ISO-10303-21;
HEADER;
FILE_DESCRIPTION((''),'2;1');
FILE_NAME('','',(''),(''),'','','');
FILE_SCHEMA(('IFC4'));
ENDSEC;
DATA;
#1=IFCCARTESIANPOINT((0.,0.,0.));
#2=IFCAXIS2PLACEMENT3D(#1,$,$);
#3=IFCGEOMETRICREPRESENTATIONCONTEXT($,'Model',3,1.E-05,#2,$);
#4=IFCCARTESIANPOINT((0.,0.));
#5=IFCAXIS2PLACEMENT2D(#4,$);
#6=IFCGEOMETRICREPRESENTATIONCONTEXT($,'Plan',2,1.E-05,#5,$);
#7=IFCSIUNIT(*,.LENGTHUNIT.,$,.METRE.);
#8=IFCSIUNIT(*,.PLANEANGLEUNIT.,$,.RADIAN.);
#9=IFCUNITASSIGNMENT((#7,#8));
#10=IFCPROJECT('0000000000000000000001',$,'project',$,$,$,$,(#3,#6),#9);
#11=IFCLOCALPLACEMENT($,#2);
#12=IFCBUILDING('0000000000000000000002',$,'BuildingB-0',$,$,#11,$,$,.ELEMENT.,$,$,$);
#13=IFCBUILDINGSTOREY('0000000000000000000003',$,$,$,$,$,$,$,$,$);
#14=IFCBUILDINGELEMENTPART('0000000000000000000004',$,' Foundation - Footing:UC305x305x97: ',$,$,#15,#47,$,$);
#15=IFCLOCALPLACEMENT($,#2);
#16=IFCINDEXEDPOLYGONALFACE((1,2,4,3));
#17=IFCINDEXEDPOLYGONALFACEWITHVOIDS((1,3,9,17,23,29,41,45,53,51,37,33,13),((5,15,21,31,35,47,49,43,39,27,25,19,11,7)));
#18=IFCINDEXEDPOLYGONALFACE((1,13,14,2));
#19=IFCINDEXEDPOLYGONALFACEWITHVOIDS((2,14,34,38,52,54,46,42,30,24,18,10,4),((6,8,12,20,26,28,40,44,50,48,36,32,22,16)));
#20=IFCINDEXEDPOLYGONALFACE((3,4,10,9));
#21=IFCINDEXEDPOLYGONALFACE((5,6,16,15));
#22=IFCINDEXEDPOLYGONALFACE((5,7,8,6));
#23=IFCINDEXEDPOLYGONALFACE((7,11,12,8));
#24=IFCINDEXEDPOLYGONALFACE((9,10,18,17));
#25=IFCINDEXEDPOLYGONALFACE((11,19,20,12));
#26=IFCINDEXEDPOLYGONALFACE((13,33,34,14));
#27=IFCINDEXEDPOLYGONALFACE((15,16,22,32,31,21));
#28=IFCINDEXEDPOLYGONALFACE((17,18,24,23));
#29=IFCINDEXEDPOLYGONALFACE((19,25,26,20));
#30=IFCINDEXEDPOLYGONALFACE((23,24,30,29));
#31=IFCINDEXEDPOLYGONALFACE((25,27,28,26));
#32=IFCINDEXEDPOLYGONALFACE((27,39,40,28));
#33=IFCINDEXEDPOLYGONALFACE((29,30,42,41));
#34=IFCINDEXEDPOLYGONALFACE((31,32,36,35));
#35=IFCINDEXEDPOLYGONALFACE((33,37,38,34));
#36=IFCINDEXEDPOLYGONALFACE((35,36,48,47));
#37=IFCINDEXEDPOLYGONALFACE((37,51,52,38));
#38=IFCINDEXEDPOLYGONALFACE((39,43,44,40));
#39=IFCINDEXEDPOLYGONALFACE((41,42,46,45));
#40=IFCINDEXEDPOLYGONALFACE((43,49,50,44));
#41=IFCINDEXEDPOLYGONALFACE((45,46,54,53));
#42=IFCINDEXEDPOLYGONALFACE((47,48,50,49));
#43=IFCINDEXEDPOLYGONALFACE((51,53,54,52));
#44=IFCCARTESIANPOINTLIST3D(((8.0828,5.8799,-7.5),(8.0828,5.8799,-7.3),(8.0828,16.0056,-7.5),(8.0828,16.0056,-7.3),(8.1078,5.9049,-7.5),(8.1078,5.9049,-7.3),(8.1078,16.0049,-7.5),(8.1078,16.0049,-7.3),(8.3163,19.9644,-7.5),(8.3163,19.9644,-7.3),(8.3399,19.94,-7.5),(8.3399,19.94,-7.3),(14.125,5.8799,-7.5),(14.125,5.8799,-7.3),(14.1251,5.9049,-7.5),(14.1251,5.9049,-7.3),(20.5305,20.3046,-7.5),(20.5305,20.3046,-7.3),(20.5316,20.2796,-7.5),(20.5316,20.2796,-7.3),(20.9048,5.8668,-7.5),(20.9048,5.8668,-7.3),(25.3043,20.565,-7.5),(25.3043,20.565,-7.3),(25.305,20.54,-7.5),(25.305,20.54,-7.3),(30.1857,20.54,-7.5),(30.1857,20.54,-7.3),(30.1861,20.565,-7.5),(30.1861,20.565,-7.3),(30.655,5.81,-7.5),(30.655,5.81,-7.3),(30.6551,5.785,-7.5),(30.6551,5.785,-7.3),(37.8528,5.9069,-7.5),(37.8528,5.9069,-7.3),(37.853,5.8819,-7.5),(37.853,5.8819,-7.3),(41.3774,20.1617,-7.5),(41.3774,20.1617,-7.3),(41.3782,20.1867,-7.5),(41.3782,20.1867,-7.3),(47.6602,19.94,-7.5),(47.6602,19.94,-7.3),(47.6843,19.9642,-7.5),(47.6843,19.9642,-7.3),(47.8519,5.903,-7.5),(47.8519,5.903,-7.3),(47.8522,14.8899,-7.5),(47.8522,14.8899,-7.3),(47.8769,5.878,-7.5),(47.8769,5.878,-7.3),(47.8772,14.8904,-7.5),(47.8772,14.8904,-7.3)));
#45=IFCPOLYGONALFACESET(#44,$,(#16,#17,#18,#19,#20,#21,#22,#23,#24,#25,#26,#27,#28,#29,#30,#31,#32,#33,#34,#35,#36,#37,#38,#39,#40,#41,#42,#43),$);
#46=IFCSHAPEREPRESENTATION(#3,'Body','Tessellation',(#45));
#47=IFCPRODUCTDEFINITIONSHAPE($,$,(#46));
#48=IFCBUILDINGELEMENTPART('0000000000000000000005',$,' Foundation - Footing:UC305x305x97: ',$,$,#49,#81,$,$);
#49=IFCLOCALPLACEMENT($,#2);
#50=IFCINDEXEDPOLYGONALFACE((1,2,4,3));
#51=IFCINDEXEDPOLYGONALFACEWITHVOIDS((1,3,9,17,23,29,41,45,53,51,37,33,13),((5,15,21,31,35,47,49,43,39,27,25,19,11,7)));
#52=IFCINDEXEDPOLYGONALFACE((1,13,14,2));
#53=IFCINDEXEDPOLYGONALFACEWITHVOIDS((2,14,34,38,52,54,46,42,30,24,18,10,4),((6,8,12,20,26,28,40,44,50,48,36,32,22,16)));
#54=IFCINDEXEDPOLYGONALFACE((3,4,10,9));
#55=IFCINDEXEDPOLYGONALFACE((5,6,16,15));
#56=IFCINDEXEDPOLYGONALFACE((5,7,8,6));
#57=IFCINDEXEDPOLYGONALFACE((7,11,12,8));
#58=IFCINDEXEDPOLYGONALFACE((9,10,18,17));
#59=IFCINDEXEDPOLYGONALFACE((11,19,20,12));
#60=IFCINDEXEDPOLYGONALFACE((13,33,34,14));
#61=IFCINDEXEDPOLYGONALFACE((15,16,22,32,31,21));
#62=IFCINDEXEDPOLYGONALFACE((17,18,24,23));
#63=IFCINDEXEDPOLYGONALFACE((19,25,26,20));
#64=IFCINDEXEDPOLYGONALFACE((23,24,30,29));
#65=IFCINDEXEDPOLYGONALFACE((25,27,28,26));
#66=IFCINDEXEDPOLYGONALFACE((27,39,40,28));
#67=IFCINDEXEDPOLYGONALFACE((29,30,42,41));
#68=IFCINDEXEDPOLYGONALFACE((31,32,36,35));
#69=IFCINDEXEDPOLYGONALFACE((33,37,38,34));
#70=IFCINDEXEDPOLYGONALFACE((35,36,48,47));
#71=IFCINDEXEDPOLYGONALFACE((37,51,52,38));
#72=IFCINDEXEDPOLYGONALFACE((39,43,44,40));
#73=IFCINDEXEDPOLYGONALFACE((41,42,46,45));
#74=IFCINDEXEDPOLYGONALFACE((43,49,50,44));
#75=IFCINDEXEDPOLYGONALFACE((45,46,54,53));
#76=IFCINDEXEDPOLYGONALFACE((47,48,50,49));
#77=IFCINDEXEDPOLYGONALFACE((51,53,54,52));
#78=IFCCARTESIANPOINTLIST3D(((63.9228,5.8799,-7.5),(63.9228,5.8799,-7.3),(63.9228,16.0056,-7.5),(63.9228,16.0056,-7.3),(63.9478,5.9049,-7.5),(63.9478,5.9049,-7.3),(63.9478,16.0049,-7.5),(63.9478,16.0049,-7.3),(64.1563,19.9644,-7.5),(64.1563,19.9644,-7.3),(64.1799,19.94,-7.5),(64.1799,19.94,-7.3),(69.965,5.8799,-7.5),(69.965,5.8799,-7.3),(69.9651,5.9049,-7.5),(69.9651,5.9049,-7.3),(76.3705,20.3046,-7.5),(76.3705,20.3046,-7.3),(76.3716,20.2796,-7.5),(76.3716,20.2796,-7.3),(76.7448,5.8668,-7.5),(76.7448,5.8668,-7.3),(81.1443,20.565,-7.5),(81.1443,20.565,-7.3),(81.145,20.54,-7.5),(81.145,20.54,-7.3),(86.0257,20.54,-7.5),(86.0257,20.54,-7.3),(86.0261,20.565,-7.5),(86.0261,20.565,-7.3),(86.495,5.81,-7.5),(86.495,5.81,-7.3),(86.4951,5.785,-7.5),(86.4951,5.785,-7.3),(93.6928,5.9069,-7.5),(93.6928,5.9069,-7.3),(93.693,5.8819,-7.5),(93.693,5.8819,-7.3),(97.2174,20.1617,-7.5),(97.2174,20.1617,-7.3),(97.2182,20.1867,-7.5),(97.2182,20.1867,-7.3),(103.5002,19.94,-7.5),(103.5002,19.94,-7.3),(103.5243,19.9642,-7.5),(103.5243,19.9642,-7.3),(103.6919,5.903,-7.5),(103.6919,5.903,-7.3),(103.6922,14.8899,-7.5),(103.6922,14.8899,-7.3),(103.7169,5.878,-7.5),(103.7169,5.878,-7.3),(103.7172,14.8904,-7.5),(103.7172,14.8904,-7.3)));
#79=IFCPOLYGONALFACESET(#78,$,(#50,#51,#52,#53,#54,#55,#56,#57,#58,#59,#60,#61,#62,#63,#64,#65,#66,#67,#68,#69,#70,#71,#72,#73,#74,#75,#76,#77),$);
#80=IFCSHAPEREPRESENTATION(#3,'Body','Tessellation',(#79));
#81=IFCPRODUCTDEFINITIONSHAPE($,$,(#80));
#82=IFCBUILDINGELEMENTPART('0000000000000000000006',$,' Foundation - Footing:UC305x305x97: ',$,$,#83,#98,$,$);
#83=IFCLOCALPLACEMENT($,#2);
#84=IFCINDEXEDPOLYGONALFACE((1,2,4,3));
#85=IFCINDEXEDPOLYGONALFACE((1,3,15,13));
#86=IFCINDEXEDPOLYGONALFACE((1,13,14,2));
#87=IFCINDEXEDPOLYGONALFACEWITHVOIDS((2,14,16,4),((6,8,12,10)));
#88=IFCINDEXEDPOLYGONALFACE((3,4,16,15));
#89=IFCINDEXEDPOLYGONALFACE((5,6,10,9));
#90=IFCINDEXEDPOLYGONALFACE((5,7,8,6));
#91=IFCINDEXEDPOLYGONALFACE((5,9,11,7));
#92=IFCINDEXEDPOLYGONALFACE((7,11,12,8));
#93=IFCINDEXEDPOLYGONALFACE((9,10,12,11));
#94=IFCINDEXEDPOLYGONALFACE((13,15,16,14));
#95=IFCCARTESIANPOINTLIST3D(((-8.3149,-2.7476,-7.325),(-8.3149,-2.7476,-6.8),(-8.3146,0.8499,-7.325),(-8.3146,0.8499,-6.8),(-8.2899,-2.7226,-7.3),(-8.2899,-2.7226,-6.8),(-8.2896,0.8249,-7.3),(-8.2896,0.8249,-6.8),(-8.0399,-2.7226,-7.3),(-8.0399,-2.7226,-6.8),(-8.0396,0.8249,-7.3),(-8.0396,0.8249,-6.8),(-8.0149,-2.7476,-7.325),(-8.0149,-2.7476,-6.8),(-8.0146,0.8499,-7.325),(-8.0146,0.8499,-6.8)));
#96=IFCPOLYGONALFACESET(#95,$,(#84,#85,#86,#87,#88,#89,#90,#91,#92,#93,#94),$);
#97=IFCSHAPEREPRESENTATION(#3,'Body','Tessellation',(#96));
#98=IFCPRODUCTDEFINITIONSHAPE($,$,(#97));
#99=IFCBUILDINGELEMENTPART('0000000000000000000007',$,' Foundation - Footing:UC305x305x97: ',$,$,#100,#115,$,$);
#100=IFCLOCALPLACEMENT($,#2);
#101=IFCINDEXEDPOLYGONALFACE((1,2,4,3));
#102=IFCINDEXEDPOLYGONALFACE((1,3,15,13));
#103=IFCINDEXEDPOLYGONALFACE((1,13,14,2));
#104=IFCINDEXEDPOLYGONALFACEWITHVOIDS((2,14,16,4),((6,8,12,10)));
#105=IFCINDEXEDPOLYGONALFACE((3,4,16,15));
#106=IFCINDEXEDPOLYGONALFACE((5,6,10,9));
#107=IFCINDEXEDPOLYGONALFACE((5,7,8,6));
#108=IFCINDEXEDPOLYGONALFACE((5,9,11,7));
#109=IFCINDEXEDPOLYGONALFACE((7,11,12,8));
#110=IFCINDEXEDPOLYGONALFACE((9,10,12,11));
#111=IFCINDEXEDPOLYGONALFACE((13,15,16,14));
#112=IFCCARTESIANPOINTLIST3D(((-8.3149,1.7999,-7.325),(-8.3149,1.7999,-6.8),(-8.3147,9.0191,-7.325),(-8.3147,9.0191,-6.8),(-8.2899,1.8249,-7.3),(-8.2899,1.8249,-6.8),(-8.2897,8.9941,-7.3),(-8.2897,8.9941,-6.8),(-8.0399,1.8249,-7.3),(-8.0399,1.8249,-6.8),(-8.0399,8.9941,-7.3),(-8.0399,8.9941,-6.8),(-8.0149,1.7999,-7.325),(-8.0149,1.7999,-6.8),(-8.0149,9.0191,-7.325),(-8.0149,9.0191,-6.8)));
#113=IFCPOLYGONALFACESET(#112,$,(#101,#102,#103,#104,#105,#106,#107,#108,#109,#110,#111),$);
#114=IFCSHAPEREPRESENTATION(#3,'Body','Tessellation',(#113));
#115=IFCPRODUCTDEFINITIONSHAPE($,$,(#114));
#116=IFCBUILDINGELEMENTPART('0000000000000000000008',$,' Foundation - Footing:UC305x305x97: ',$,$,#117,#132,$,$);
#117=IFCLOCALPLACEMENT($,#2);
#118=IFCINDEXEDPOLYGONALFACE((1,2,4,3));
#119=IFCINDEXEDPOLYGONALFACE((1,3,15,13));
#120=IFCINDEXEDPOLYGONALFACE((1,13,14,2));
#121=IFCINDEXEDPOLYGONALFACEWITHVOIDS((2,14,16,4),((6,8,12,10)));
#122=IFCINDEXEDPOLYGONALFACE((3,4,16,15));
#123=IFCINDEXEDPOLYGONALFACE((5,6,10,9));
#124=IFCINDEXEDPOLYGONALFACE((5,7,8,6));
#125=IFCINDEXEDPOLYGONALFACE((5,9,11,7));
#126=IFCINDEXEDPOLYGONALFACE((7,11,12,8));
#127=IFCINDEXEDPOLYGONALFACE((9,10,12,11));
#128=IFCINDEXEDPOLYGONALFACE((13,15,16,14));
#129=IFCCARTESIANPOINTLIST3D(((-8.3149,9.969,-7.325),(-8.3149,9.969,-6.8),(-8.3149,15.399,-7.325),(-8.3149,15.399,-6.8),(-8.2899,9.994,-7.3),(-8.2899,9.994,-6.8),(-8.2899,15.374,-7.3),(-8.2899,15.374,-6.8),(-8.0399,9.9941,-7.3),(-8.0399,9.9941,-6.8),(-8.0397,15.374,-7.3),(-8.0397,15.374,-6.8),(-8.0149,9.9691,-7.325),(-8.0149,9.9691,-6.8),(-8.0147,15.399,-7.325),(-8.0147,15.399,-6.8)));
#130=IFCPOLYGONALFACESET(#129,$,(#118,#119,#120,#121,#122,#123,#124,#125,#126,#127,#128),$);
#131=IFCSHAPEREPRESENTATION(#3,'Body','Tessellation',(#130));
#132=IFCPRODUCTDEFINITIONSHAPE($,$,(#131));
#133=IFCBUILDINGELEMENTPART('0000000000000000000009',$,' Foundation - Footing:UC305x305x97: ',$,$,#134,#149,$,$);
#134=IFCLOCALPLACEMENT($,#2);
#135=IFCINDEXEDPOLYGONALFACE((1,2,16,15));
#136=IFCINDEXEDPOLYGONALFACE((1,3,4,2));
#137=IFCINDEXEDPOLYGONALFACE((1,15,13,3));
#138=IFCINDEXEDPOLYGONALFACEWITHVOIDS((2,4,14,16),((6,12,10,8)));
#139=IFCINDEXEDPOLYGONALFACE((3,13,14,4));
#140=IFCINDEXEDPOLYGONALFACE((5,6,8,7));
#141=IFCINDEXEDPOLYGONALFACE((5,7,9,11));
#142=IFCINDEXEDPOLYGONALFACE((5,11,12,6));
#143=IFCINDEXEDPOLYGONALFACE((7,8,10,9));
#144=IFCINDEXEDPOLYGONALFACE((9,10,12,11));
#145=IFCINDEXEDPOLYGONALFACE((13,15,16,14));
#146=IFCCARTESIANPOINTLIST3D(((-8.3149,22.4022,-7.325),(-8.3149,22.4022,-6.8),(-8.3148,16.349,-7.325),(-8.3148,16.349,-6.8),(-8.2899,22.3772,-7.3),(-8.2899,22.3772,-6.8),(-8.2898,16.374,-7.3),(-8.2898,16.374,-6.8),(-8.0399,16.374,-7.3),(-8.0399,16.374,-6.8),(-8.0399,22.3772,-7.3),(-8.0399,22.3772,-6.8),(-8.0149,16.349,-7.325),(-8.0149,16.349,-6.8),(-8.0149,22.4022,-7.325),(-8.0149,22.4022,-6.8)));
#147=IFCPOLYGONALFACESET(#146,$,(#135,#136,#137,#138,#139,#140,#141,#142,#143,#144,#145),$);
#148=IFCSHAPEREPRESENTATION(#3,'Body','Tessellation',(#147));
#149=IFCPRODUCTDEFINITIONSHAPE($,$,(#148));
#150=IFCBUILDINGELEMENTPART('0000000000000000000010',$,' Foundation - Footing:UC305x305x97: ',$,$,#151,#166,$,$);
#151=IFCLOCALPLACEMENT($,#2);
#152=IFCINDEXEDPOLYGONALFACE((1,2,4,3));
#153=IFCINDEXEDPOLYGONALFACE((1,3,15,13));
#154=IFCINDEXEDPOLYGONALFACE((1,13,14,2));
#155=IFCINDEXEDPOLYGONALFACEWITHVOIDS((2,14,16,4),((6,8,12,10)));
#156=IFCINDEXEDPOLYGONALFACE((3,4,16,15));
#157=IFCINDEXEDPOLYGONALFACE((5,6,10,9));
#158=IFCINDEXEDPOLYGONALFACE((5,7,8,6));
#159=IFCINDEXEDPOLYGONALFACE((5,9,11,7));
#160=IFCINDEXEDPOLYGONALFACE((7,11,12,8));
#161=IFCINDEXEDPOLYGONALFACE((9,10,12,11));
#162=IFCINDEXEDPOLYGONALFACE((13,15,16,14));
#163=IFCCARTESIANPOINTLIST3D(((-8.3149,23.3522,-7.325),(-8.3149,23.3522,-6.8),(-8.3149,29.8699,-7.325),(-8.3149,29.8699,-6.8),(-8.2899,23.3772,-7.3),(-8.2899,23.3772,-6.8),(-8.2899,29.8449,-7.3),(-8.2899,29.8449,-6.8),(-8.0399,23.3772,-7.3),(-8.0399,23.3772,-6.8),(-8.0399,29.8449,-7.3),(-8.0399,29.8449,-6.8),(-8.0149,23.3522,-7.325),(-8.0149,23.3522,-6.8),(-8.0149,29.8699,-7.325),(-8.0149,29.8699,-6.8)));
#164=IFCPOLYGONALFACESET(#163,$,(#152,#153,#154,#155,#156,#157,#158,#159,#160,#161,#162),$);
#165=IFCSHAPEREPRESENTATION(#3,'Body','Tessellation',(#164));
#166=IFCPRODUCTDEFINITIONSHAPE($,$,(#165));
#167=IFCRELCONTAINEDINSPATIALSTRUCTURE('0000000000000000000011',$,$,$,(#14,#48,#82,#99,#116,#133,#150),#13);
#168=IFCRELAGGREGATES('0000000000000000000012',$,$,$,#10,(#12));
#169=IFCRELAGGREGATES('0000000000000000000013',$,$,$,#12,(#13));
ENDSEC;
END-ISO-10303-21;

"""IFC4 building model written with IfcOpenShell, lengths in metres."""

from ifc_helpers import new_model, si_unit, origin, origin_2d, place, context, project, spatial, polyline, outline, extrude, element, save


model = new_model("IFC4")

# Units and contexts
model_context = context("Model", 3, precision=1e-05, world=origin())
plan_context = context("Plan", 2, precision=1e-05, world=origin_2d())
ifc_project = project(units=[si_unit("LENGTHUNIT", "METRE"), si_unit("PLANEANGLEUNIT", "RADIAN")], contexts=[model_context, plan_context])

# Building, storey
building_placement = place(None, origin())
building = spatial("IfcBuilding", under=ifc_project, at=building_placement, Name="BuildingB-0", CompositionType="ELEMENT")
storey = spatial("IfcBuildingStorey", under=building)

# Building element parts, openings
building_element_part_1 = element("IfcBuildingElementPart", 1, inside=storey, Name=" Foundation - Footing:UC305x305x97: ", context=model_context, shape_type="SweptSolid", body=[
    extrude(outline(polyline([(8.3163, 19.9644, -7.5), (20.5305, 20.3046, -7.5), (25.3043, 20.565, -7.5), (30.1861, 20.565, -7.5), (41.3782, 20.1867, -7.5), (47.6843, 19.9642, -7.5), (47.8772, 14.8904, -7.5), (47.8769, 5.878, -7.5), (37.853, 5.8819, -7.5), (30.6551, 5.785, -7.5), (20.9046, 5.8418, -7.5), (14.125, 5.8799, -7.5), (8.0828, 5.8799, -7.5), (8.0828, 16.0056, -7.5), (8.3163, 19.9644, -7.5)])), None, (0.0, 0.0, 1.0), 0.2),
])
element("IfcOpeningElement", 2, inside=storey, cuts=building_element_part_1, context=model_context, shape_type="SweptSolid", body=[
    extrude(outline(polyline([(8.3399, 19.94, -7.5), (20.5316, 20.2796, -7.5), (25.305, 20.54, -7.5), (30.1857, 20.54, -7.5), (41.3774, 20.1617, -7.5), (47.6602, 19.94, -7.5), (47.8522, 14.8899, -7.5), (47.8519, 5.903, -7.5), (37.8528, 5.9069, -7.5), (30.655, 5.81, -7.5), (20.9048, 5.8668, -7.5), (14.1251, 5.9049, -7.5), (8.1078, 5.9049, -7.5), (8.1078, 16.0049, -7.5), (8.3399, 19.94, -7.5)])), None, (0.0, 0.0, 1.0), 0.2),
])
building_element_part_2 = element("IfcBuildingElementPart", 3, inside=storey, Name=" Foundation - Footing:UC305x305x97: ", context=model_context, shape_type="SweptSolid", body=[
    extrude(outline(polyline([(64.1563, 19.9644, -7.5), (76.3705, 20.3046, -7.5), (81.1443, 20.565, -7.5), (86.0261, 20.565, -7.5), (97.2182, 20.1867, -7.5), (103.5243, 19.9642, -7.5), (103.7172, 14.8904, -7.5), (103.7169, 5.878, -7.5), (93.693, 5.8819, -7.5), (86.4951, 5.785, -7.5), (76.7446, 5.8418, -7.5), (69.965, 5.8799, -7.5), (63.9228, 5.8799, -7.5), (63.9228, 16.0056, -7.5), (64.1563, 19.9644, -7.5)])), None, (0.0, 0.0, 1.0), 0.2),
])
element("IfcOpeningElement", 4, inside=storey, cuts=building_element_part_2, context=model_context, shape_type="SweptSolid", body=[
    extrude(outline(polyline([(64.1799, 19.94, -7.5), (76.3716, 20.2796, -7.5), (81.145, 20.54, -7.5), (86.0257, 20.54, -7.5), (97.2174, 20.1617, -7.5), (103.5002, 19.94, -7.5), (103.6922, 14.8899, -7.5), (103.6919, 5.903, -7.5), (93.6928, 5.9069, -7.5), (86.495, 5.81, -7.5), (76.7448, 5.8668, -7.5), (69.9651, 5.9049, -7.5), (63.9478, 5.9049, -7.5), (63.9478, 16.0049, -7.5), (64.1799, 19.94, -7.5)])), None, (0.0, 0.0, 1.0), 0.2),
])
building_element_part_3 = element("IfcBuildingElementPart", 5, inside=storey, Name=" Foundation - Footing:UC305x305x97: ", context=model_context, shape_type="SweptSolid", body=[
    extrude(outline(polyline([(-8.3149, -2.7476, -7.325), (-8.0149, -2.7476, -7.325), (-8.0146, 0.8499, -7.325), (-8.3146, 0.8499, -7.325), (-8.3149, -2.7476, -7.325)])), None, (0.0, 0.0, 1.0), 0.525),
])
element("IfcOpeningElement", 6, inside=storey, cuts=building_element_part_3, context=model_context, shape_type="SweptSolid", body=[
    extrude(outline(polyline([(-8.2899, -2.7226, -7.3), (-8.0399, -2.7226, -7.3), (-8.0396, 0.8249, -7.3), (-8.2896, 0.8249, -7.3), (-8.2899, -2.7226, -7.3)])), None, (0.0, 0.0, 1.0), 0.5),
])
building_element_part_4 = element("IfcBuildingElementPart", 7, inside=storey, Name=" Foundation - Footing:UC305x305x97: ", context=model_context, shape_type="SweptSolid", body=[
    extrude(outline(polyline([(-8.3149, 1.7999, -7.325), (-8.0149, 1.7999, -7.325), (-8.0149, 9.0191, -7.325), (-8.3147, 9.0191, -7.325), (-8.3149, 1.7999, -7.325)])), None, (0.0, 0.0, 1.0), 0.525),
])
element("IfcOpeningElement", 8, inside=storey, cuts=building_element_part_4, context=model_context, shape_type="SweptSolid", body=[
    extrude(outline(polyline([(-8.2899, 1.8249, -7.3), (-8.0399, 1.8249, -7.3), (-8.0399, 8.9941, -7.3), (-8.2897, 8.9941, -7.3), (-8.2899, 1.8249, -7.3)])), None, (0.0, 0.0, 1.0), 0.5),
])
building_element_part_5 = element("IfcBuildingElementPart", 9, inside=storey, Name=" Foundation - Footing:UC305x305x97: ", context=model_context, shape_type="SweptSolid", body=[
    extrude(outline(polyline([(-8.3149, 9.969, -7.325), (-8.0149, 9.9691, -7.325), (-8.0147, 15.399, -7.325), (-8.3149, 15.399, -7.325), (-8.3149, 9.969, -7.325)])), None, (0.0, 0.0, 1.0), 0.525),
])
element("IfcOpeningElement", 10, inside=storey, cuts=building_element_part_5, context=model_context, shape_type="SweptSolid", body=[
    extrude(outline(polyline([(-8.2899, 9.994, -7.3), (-8.0399, 9.9941, -7.3), (-8.0397, 15.374, -7.3), (-8.2899, 15.374, -7.3), (-8.2899, 9.994, -7.3)])), None, (0.0, 0.0, 1.0), 0.5),
])
building_element_part_6 = element("IfcBuildingElementPart", 11, inside=storey, Name=" Foundation - Footing:UC305x305x97: ", context=model_context, shape_type="SweptSolid", body=[
    extrude(outline(polyline([(-8.3148, 16.349, -7.325), (-8.0149, 16.349, -7.325), (-8.0149, 22.4022, -7.325), (-8.3149, 22.4022, -7.325), (-8.3148, 16.349, -7.325)])), None, (0.0, 0.0, 1.0), 0.525),
])
element("IfcOpeningElement", 12, inside=storey, cuts=building_element_part_6, context=model_context, shape_type="SweptSolid", body=[
    extrude(outline(polyline([(-8.2898, 16.374, -7.3), (-8.0399, 16.374, -7.3), (-8.0399, 22.3772, -7.3), (-8.2899, 22.3772, -7.3), (-8.2898, 16.374, -7.3)])), None, (0.0, 0.0, 1.0), 0.5),
])
building_element_part_7 = element("IfcBuildingElementPart", 13, inside=storey, Name=" Foundation - Footing:UC305x305x97: ", context=model_context, shape_type="SweptSolid", body=[
    extrude(outline(polyline([(-8.3149, 23.3522, -7.325), (-8.0149, 23.3522, -7.325), (-8.0149, 29.8699, -7.325), (-8.3149, 29.8699, -7.325), (-8.3149, 23.3522, -7.325)])), None, (0.0, 0.0, 1.0), 0.525),
])
element("IfcOpeningElement", 14, inside=storey, cuts=building_element_part_7, context=model_context, shape_type="SweptSolid", body=[
    extrude(outline(polyline([(-8.2899, 23.3772, -7.3), (-8.0399, 23.3772, -7.3), (-8.0399, 29.8449, -7.3), (-8.2899, 29.8449, -7.3), (-8.2899, 23.3772, -7.3)])), None, (0.0, 0.0, 1.0), 0.5),
])

save(model, "model.ifc")
